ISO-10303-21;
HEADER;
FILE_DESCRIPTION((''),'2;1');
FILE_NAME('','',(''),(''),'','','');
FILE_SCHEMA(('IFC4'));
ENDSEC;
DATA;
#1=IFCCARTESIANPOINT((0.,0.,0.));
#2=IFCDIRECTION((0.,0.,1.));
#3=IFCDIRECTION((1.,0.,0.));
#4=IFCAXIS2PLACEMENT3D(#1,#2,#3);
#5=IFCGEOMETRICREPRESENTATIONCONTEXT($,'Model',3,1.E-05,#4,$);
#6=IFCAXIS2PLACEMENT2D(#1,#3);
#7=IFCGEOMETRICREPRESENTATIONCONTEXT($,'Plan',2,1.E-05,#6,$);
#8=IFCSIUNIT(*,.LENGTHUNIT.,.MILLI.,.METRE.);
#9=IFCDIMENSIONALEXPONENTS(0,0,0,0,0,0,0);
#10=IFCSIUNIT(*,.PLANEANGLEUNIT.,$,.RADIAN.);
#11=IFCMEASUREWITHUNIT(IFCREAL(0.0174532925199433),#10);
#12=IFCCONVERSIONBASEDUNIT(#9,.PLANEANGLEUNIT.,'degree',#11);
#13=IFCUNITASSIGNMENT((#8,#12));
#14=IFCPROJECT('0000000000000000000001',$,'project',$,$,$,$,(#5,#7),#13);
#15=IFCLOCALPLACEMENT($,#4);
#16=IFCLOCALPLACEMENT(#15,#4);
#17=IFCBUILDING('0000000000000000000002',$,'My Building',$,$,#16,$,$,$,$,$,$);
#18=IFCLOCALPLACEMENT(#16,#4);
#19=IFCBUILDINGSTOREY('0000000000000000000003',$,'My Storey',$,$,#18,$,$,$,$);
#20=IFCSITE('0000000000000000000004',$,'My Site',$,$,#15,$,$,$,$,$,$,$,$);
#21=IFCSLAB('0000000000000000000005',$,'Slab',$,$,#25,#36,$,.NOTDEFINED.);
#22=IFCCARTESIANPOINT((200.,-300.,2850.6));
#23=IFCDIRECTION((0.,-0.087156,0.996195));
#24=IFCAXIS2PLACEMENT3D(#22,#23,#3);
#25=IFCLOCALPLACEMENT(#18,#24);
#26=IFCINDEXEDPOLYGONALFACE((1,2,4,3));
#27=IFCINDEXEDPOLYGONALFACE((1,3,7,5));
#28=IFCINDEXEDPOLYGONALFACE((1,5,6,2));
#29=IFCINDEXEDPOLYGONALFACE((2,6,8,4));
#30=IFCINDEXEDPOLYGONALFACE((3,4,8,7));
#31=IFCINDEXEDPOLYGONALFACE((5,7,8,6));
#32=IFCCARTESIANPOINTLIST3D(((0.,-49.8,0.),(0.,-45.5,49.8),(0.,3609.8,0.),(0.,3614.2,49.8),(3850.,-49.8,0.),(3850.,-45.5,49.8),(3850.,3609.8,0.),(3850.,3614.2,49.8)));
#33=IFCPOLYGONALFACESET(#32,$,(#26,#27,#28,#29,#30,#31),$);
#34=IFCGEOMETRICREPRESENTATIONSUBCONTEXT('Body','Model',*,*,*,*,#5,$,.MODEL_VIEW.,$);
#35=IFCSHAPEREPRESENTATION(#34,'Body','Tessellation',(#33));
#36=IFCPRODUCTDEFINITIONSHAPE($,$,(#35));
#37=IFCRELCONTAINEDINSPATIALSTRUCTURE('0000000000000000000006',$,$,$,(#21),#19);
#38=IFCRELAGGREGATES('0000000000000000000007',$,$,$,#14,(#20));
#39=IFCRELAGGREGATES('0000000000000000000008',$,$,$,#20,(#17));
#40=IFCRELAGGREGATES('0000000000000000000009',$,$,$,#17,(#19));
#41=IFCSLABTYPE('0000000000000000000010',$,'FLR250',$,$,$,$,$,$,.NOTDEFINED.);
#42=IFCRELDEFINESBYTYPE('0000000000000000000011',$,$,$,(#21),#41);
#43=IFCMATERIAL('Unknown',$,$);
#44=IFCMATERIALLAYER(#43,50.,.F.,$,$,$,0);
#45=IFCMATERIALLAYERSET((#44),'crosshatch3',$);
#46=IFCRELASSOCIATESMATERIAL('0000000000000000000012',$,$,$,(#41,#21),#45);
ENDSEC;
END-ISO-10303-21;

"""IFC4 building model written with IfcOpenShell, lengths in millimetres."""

from ifc_helpers import new_model, entity, si_unit, converted_unit, frame, frame_2d, origin_with_axes, place, context, subcontext, project, spatial, line, indexed_curve, outline, extrude, material, layer, layer_set, layer_usage, type_object, element, save


model = new_model("IFC4")

# Units and contexts
model_context = context("Model", 3, precision=1e-05, world=origin_with_axes())
plan_context = context("Plan", 2, precision=1e-05, world=frame_2d((0.0, 0.0, 0.0), x_axis=(1.0, 0.0, 0.0)))
body_context = subcontext(model_context, "Body", "Model", "MODEL_VIEW")
ifc_project = project(units=[si_unit("LENGTHUNIT", "METRE", prefix="MILLI"), converted_unit("PLANEANGLEUNIT", "degree", entity("IfcReal", 0.0174532925199433), si_unit("PLANEANGLEUNIT", "RADIAN"), dimensions=[0, 0, 0, 0, 0, 0, 0])], contexts=[model_context, plan_context])

# Site, building, storey
site_placement = place(None, origin_with_axes())
site = spatial("IfcSite", under=ifc_project, at=site_placement, Name="My Site")
building_placement = place(site_placement, origin_with_axes())
building = spatial("IfcBuilding", under=site, at=building_placement, Name="My Building")
storey_placement = place(building_placement, origin_with_axes())
storey = spatial("IfcBuildingStorey", under=building, at=storey_placement, Name="My Storey")

# Shared definitions
ifc_material = material(Name="Unknown")

# Slab
ifc_layer_1 = layer(ifc_material, 50.0, ventilated=False, Priority=0)
ifc_layer_set_1 = layer_set([ifc_layer_1], Name="crosshatch3")
ifc_layer_usage_1 = layer_usage(ifc_layer_set_1, "AXIS3", "POSITIVE", 0.0)
slab_type_1 = type_object("IfcSlabType", Name="FLR250", PredefinedType="NOTDEFINED", material=ifc_layer_set_1)
slab_1_placement = place(storey_placement, frame((200.0, -300.0, 2850.6), z_axis=(0.0, -0.087156, 0.996195), x_axis=(1.0, 0.0, 0.0)))
element("IfcSlab", 1, at=slab_1_placement, inside=storey, type_object=slab_type_1, material=ifc_layer_usage_1, Name="Slab", PredefinedType="NOTDEFINED", context=body_context, shape_type="SweptSolid", body=[
    extrude(outline(indexed_curve([(0.0, -49.8), (3850.0, -49.8), (3850.0, 3609.8), (0.0, 3609.8)], segments=[line(4, 1), line(1, 2), line(2, 3), line(3, 4)], self_intersect=False)), None, (0.0, 0.087156, 0.996195), 50.0),
])

save(model, "model.ifc")
